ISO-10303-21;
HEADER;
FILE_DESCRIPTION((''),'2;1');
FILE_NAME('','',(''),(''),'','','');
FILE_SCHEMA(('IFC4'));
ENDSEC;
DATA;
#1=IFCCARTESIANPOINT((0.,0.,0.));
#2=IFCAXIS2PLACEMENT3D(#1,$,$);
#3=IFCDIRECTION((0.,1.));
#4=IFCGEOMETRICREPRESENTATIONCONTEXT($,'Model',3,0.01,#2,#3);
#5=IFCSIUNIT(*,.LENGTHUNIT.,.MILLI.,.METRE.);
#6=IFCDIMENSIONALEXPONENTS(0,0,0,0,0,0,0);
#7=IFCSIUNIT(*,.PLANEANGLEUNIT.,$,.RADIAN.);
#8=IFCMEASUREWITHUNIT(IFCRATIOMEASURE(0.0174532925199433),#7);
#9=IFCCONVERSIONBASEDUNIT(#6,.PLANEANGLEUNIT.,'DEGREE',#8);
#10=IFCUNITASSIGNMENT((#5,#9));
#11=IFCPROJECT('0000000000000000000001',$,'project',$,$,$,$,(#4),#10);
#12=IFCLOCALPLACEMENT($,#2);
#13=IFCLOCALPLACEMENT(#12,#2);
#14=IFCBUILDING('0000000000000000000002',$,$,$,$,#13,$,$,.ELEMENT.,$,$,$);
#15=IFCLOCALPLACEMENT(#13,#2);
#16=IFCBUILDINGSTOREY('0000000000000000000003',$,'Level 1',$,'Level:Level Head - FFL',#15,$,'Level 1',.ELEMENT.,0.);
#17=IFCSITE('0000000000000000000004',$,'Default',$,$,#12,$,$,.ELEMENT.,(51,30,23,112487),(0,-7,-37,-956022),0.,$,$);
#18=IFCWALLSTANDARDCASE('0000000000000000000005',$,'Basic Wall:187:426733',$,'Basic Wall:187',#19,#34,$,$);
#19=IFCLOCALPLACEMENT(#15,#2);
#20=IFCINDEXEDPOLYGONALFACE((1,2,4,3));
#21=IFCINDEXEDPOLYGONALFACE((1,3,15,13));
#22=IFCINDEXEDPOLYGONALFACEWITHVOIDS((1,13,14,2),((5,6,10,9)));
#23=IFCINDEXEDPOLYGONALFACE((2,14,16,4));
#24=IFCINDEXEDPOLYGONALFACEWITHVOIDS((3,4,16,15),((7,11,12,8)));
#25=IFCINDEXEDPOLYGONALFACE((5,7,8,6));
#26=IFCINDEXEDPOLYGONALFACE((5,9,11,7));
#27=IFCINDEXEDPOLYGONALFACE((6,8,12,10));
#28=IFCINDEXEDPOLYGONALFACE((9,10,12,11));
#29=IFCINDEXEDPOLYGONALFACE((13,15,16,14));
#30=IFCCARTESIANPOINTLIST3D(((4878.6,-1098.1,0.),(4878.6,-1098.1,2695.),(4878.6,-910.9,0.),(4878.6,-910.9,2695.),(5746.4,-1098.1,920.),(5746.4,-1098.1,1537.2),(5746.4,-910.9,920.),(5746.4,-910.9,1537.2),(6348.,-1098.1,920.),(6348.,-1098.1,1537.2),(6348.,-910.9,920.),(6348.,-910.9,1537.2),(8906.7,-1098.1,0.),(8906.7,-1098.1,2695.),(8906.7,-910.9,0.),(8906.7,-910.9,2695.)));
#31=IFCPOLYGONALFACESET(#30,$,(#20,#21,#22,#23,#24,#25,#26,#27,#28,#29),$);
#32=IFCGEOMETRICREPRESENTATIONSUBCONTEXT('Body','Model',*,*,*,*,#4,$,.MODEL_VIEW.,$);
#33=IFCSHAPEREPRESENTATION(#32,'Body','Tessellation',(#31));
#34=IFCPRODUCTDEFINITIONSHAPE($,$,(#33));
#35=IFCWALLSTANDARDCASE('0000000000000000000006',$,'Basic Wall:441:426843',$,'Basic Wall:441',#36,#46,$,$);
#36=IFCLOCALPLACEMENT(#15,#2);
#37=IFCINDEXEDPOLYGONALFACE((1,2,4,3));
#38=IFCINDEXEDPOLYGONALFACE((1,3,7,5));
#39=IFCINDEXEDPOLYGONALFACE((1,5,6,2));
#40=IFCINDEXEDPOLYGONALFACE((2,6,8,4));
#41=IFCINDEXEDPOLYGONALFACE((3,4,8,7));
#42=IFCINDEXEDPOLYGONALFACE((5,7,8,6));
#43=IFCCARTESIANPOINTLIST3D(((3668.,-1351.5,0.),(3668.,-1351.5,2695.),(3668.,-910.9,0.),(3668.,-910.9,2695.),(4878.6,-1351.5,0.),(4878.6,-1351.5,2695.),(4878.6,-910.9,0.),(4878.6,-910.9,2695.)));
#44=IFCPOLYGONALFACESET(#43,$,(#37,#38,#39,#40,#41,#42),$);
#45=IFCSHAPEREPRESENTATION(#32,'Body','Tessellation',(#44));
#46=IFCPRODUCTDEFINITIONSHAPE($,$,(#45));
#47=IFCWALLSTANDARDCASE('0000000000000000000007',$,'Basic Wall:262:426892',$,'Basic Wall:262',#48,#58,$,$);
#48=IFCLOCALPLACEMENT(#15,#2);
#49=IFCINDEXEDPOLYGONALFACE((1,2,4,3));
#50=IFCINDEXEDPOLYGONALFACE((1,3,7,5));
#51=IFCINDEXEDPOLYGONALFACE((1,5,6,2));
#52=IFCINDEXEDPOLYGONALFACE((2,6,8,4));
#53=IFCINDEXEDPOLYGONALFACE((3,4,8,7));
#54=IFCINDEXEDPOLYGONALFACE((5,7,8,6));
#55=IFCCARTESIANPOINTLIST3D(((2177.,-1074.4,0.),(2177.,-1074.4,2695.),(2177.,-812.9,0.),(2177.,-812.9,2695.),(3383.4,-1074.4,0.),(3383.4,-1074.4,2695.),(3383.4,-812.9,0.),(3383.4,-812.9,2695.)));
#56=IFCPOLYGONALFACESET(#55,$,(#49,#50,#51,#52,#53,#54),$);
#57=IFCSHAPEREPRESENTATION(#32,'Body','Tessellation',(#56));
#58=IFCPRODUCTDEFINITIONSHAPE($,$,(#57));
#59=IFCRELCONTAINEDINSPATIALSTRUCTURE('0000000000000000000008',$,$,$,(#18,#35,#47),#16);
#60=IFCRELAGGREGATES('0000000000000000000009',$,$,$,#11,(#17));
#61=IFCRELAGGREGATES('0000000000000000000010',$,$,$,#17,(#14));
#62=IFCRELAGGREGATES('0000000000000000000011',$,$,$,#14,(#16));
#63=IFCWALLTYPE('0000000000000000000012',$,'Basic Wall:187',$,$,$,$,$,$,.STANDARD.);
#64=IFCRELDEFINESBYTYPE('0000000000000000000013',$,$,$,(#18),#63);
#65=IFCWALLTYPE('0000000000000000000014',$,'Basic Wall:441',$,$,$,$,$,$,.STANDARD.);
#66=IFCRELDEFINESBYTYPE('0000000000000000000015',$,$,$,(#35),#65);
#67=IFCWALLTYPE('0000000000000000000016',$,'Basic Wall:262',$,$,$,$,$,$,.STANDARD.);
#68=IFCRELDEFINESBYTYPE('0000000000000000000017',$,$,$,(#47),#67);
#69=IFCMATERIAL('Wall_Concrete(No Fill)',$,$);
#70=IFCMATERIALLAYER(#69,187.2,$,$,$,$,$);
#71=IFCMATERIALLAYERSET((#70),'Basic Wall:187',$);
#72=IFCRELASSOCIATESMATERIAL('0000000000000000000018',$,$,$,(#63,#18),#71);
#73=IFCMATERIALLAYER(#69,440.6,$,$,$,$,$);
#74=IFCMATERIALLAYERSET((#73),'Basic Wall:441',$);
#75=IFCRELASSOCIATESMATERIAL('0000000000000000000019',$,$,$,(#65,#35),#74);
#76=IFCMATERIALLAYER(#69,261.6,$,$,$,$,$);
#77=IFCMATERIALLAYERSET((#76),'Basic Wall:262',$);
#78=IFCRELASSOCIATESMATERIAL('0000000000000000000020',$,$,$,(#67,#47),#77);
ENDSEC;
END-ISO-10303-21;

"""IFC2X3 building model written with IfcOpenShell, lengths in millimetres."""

from ifc_helpers import new_model, entity, si_unit, converted_unit, direction, frame, frame_2d, origin, place, context, subcontext, project, spatial, rectangle, extrude, material, layer, layer_set, layer_usage, type_object, element, save


model = new_model("IFC2X3")

# Units and contexts
model_context = context("Model", 3, precision=0.01, world=origin(), true_north=direction((0.0, 1.0)))
body_context = subcontext(model_context, "Body", "Model", "MODEL_VIEW")
ifc_project = project(units=[si_unit("LENGTHUNIT", "METRE", prefix="MILLI"), converted_unit("PLANEANGLEUNIT", "DEGREE", entity("IfcRatioMeasure", 0.0174532925199433), si_unit("PLANEANGLEUNIT", "RADIAN"), dimensions=[0, 0, 0, 0, 0, 0, 0])], contexts=[model_context])

# Site, building, storey
site_placement = place(None, origin())
site = spatial("IfcSite", under=ifc_project, at=site_placement, Name="Default", CompositionType="ELEMENT", RefLatitude=(51, 30, 23, 112487), RefLongitude=(0, -7, -37, -956022), RefElevation=0.0)
building_placement = place(site_placement, origin())
building = spatial("IfcBuilding", under=site, at=building_placement, CompositionType="ELEMENT")
storey_placement = place(building_placement, origin())
storey = spatial("IfcBuildingStorey", under=building, at=storey_placement, Name="Level 1", ObjectType="Level:Level Head - FFL", LongName="Level 1", CompositionType="ELEMENT", Elevation=0.0)

# Wall, opening
ifc_material = material(Name="Wall_Concrete(No Fill)")
ifc_layer_1 = layer(ifc_material, 187.2)
ifc_layer_set_1 = layer_set([ifc_layer_1], Name="Basic Wall:187")
ifc_layer_usage_1 = layer_usage(ifc_layer_set_1, "AXIS2", "NEGATIVE", 93.6)
wall_type_1 = type_object("IfcWallType", Name="Basic Wall:187", PredefinedType="STANDARD", material=ifc_layer_set_1)
wall_1_placement = place(storey_placement, frame((4878.6, -1004.5, 0.0)))
wall_1 = element("IfcWallStandardCase", 1, at=wall_1_placement, inside=storey, type_object=wall_type_1, material=ifc_layer_usage_1, Name="Basic Wall:187:426733", ObjectType="Basic Wall:187", context=body_context, shape_type="SweptSolid", body=[
    extrude(rectangle(XDim=4028.1, YDim=187.2, at=frame_2d((2014.0, 0.0), x_axis=(-1.0, 0.0))), origin(), (0.0, 0.0, 1.0), 2695.0),
])
opening_1_placement = place(wall_1_placement, origin())
element("IfcOpeningElement", 2, at=opening_1_placement, cuts=wall_1, ObjectType="Opening", context=body_context, shape_type="SweptSolid", body=[
    extrude(rectangle(XDim=617.2, YDim=601.7, at=frame_2d((0.0, 0.0), x_axis=(1.0, 0.0))), frame((1168.6, -93.6, 1228.6), z_axis=(0.0, 1.0, 0.0), x_axis=(0.0, 0.0, -1.0)), (0.0, 0.0, 1.0), 187.2),
])

# Wall
ifc_layer_2 = layer(ifc_material, 440.6)
ifc_layer_set_2 = layer_set([ifc_layer_2], Name="Basic Wall:441")
ifc_layer_usage_2 = layer_usage(ifc_layer_set_2, "AXIS2", "NEGATIVE", 220.3)
wall_type_2 = type_object("IfcWallType", Name="Basic Wall:441", PredefinedType="STANDARD", material=ifc_layer_set_2)
wall_2_placement = place(storey_placement, frame((3668.0, -1131.2, 0.0)))
element("IfcWallStandardCase", 3, at=wall_2_placement, inside=storey, type_object=wall_type_2, material=ifc_layer_usage_2, Name="Basic Wall:441:426843", ObjectType="Basic Wall:441", context=body_context, shape_type="SweptSolid", body=[
    extrude(rectangle(XDim=1210.7, YDim=440.6, at=frame_2d((605.3, 0.0), x_axis=(-1.0, 0.0))), origin(), (0.0, 0.0, 1.0), 2695.0),
])

# Wall
ifc_layer_3 = layer(ifc_material, 261.6)
ifc_layer_set_3 = layer_set([ifc_layer_3], Name="Basic Wall:262")
ifc_layer_usage_3 = layer_usage(ifc_layer_set_3, "AXIS2", "NEGATIVE", 130.8)
wall_type_3 = type_object("IfcWallType", Name="Basic Wall:262", PredefinedType="STANDARD", material=ifc_layer_set_3)
wall_3_placement = place(storey_placement, frame((2177.0, -943.6, 0.0)))
element("IfcWallStandardCase", 4, at=wall_3_placement, inside=storey, type_object=wall_type_3, material=ifc_layer_usage_3, Name="Basic Wall:262:426892", ObjectType="Basic Wall:262", context=body_context, shape_type="SweptSolid", body=[
    extrude(rectangle(XDim=1206.4, YDim=261.6, at=frame_2d((603.2, 0.0), x_axis=(-1.0, 0.0))), origin(), (0.0, 0.0, 1.0), 2695.0),
])

save(model, "model.ifc")
